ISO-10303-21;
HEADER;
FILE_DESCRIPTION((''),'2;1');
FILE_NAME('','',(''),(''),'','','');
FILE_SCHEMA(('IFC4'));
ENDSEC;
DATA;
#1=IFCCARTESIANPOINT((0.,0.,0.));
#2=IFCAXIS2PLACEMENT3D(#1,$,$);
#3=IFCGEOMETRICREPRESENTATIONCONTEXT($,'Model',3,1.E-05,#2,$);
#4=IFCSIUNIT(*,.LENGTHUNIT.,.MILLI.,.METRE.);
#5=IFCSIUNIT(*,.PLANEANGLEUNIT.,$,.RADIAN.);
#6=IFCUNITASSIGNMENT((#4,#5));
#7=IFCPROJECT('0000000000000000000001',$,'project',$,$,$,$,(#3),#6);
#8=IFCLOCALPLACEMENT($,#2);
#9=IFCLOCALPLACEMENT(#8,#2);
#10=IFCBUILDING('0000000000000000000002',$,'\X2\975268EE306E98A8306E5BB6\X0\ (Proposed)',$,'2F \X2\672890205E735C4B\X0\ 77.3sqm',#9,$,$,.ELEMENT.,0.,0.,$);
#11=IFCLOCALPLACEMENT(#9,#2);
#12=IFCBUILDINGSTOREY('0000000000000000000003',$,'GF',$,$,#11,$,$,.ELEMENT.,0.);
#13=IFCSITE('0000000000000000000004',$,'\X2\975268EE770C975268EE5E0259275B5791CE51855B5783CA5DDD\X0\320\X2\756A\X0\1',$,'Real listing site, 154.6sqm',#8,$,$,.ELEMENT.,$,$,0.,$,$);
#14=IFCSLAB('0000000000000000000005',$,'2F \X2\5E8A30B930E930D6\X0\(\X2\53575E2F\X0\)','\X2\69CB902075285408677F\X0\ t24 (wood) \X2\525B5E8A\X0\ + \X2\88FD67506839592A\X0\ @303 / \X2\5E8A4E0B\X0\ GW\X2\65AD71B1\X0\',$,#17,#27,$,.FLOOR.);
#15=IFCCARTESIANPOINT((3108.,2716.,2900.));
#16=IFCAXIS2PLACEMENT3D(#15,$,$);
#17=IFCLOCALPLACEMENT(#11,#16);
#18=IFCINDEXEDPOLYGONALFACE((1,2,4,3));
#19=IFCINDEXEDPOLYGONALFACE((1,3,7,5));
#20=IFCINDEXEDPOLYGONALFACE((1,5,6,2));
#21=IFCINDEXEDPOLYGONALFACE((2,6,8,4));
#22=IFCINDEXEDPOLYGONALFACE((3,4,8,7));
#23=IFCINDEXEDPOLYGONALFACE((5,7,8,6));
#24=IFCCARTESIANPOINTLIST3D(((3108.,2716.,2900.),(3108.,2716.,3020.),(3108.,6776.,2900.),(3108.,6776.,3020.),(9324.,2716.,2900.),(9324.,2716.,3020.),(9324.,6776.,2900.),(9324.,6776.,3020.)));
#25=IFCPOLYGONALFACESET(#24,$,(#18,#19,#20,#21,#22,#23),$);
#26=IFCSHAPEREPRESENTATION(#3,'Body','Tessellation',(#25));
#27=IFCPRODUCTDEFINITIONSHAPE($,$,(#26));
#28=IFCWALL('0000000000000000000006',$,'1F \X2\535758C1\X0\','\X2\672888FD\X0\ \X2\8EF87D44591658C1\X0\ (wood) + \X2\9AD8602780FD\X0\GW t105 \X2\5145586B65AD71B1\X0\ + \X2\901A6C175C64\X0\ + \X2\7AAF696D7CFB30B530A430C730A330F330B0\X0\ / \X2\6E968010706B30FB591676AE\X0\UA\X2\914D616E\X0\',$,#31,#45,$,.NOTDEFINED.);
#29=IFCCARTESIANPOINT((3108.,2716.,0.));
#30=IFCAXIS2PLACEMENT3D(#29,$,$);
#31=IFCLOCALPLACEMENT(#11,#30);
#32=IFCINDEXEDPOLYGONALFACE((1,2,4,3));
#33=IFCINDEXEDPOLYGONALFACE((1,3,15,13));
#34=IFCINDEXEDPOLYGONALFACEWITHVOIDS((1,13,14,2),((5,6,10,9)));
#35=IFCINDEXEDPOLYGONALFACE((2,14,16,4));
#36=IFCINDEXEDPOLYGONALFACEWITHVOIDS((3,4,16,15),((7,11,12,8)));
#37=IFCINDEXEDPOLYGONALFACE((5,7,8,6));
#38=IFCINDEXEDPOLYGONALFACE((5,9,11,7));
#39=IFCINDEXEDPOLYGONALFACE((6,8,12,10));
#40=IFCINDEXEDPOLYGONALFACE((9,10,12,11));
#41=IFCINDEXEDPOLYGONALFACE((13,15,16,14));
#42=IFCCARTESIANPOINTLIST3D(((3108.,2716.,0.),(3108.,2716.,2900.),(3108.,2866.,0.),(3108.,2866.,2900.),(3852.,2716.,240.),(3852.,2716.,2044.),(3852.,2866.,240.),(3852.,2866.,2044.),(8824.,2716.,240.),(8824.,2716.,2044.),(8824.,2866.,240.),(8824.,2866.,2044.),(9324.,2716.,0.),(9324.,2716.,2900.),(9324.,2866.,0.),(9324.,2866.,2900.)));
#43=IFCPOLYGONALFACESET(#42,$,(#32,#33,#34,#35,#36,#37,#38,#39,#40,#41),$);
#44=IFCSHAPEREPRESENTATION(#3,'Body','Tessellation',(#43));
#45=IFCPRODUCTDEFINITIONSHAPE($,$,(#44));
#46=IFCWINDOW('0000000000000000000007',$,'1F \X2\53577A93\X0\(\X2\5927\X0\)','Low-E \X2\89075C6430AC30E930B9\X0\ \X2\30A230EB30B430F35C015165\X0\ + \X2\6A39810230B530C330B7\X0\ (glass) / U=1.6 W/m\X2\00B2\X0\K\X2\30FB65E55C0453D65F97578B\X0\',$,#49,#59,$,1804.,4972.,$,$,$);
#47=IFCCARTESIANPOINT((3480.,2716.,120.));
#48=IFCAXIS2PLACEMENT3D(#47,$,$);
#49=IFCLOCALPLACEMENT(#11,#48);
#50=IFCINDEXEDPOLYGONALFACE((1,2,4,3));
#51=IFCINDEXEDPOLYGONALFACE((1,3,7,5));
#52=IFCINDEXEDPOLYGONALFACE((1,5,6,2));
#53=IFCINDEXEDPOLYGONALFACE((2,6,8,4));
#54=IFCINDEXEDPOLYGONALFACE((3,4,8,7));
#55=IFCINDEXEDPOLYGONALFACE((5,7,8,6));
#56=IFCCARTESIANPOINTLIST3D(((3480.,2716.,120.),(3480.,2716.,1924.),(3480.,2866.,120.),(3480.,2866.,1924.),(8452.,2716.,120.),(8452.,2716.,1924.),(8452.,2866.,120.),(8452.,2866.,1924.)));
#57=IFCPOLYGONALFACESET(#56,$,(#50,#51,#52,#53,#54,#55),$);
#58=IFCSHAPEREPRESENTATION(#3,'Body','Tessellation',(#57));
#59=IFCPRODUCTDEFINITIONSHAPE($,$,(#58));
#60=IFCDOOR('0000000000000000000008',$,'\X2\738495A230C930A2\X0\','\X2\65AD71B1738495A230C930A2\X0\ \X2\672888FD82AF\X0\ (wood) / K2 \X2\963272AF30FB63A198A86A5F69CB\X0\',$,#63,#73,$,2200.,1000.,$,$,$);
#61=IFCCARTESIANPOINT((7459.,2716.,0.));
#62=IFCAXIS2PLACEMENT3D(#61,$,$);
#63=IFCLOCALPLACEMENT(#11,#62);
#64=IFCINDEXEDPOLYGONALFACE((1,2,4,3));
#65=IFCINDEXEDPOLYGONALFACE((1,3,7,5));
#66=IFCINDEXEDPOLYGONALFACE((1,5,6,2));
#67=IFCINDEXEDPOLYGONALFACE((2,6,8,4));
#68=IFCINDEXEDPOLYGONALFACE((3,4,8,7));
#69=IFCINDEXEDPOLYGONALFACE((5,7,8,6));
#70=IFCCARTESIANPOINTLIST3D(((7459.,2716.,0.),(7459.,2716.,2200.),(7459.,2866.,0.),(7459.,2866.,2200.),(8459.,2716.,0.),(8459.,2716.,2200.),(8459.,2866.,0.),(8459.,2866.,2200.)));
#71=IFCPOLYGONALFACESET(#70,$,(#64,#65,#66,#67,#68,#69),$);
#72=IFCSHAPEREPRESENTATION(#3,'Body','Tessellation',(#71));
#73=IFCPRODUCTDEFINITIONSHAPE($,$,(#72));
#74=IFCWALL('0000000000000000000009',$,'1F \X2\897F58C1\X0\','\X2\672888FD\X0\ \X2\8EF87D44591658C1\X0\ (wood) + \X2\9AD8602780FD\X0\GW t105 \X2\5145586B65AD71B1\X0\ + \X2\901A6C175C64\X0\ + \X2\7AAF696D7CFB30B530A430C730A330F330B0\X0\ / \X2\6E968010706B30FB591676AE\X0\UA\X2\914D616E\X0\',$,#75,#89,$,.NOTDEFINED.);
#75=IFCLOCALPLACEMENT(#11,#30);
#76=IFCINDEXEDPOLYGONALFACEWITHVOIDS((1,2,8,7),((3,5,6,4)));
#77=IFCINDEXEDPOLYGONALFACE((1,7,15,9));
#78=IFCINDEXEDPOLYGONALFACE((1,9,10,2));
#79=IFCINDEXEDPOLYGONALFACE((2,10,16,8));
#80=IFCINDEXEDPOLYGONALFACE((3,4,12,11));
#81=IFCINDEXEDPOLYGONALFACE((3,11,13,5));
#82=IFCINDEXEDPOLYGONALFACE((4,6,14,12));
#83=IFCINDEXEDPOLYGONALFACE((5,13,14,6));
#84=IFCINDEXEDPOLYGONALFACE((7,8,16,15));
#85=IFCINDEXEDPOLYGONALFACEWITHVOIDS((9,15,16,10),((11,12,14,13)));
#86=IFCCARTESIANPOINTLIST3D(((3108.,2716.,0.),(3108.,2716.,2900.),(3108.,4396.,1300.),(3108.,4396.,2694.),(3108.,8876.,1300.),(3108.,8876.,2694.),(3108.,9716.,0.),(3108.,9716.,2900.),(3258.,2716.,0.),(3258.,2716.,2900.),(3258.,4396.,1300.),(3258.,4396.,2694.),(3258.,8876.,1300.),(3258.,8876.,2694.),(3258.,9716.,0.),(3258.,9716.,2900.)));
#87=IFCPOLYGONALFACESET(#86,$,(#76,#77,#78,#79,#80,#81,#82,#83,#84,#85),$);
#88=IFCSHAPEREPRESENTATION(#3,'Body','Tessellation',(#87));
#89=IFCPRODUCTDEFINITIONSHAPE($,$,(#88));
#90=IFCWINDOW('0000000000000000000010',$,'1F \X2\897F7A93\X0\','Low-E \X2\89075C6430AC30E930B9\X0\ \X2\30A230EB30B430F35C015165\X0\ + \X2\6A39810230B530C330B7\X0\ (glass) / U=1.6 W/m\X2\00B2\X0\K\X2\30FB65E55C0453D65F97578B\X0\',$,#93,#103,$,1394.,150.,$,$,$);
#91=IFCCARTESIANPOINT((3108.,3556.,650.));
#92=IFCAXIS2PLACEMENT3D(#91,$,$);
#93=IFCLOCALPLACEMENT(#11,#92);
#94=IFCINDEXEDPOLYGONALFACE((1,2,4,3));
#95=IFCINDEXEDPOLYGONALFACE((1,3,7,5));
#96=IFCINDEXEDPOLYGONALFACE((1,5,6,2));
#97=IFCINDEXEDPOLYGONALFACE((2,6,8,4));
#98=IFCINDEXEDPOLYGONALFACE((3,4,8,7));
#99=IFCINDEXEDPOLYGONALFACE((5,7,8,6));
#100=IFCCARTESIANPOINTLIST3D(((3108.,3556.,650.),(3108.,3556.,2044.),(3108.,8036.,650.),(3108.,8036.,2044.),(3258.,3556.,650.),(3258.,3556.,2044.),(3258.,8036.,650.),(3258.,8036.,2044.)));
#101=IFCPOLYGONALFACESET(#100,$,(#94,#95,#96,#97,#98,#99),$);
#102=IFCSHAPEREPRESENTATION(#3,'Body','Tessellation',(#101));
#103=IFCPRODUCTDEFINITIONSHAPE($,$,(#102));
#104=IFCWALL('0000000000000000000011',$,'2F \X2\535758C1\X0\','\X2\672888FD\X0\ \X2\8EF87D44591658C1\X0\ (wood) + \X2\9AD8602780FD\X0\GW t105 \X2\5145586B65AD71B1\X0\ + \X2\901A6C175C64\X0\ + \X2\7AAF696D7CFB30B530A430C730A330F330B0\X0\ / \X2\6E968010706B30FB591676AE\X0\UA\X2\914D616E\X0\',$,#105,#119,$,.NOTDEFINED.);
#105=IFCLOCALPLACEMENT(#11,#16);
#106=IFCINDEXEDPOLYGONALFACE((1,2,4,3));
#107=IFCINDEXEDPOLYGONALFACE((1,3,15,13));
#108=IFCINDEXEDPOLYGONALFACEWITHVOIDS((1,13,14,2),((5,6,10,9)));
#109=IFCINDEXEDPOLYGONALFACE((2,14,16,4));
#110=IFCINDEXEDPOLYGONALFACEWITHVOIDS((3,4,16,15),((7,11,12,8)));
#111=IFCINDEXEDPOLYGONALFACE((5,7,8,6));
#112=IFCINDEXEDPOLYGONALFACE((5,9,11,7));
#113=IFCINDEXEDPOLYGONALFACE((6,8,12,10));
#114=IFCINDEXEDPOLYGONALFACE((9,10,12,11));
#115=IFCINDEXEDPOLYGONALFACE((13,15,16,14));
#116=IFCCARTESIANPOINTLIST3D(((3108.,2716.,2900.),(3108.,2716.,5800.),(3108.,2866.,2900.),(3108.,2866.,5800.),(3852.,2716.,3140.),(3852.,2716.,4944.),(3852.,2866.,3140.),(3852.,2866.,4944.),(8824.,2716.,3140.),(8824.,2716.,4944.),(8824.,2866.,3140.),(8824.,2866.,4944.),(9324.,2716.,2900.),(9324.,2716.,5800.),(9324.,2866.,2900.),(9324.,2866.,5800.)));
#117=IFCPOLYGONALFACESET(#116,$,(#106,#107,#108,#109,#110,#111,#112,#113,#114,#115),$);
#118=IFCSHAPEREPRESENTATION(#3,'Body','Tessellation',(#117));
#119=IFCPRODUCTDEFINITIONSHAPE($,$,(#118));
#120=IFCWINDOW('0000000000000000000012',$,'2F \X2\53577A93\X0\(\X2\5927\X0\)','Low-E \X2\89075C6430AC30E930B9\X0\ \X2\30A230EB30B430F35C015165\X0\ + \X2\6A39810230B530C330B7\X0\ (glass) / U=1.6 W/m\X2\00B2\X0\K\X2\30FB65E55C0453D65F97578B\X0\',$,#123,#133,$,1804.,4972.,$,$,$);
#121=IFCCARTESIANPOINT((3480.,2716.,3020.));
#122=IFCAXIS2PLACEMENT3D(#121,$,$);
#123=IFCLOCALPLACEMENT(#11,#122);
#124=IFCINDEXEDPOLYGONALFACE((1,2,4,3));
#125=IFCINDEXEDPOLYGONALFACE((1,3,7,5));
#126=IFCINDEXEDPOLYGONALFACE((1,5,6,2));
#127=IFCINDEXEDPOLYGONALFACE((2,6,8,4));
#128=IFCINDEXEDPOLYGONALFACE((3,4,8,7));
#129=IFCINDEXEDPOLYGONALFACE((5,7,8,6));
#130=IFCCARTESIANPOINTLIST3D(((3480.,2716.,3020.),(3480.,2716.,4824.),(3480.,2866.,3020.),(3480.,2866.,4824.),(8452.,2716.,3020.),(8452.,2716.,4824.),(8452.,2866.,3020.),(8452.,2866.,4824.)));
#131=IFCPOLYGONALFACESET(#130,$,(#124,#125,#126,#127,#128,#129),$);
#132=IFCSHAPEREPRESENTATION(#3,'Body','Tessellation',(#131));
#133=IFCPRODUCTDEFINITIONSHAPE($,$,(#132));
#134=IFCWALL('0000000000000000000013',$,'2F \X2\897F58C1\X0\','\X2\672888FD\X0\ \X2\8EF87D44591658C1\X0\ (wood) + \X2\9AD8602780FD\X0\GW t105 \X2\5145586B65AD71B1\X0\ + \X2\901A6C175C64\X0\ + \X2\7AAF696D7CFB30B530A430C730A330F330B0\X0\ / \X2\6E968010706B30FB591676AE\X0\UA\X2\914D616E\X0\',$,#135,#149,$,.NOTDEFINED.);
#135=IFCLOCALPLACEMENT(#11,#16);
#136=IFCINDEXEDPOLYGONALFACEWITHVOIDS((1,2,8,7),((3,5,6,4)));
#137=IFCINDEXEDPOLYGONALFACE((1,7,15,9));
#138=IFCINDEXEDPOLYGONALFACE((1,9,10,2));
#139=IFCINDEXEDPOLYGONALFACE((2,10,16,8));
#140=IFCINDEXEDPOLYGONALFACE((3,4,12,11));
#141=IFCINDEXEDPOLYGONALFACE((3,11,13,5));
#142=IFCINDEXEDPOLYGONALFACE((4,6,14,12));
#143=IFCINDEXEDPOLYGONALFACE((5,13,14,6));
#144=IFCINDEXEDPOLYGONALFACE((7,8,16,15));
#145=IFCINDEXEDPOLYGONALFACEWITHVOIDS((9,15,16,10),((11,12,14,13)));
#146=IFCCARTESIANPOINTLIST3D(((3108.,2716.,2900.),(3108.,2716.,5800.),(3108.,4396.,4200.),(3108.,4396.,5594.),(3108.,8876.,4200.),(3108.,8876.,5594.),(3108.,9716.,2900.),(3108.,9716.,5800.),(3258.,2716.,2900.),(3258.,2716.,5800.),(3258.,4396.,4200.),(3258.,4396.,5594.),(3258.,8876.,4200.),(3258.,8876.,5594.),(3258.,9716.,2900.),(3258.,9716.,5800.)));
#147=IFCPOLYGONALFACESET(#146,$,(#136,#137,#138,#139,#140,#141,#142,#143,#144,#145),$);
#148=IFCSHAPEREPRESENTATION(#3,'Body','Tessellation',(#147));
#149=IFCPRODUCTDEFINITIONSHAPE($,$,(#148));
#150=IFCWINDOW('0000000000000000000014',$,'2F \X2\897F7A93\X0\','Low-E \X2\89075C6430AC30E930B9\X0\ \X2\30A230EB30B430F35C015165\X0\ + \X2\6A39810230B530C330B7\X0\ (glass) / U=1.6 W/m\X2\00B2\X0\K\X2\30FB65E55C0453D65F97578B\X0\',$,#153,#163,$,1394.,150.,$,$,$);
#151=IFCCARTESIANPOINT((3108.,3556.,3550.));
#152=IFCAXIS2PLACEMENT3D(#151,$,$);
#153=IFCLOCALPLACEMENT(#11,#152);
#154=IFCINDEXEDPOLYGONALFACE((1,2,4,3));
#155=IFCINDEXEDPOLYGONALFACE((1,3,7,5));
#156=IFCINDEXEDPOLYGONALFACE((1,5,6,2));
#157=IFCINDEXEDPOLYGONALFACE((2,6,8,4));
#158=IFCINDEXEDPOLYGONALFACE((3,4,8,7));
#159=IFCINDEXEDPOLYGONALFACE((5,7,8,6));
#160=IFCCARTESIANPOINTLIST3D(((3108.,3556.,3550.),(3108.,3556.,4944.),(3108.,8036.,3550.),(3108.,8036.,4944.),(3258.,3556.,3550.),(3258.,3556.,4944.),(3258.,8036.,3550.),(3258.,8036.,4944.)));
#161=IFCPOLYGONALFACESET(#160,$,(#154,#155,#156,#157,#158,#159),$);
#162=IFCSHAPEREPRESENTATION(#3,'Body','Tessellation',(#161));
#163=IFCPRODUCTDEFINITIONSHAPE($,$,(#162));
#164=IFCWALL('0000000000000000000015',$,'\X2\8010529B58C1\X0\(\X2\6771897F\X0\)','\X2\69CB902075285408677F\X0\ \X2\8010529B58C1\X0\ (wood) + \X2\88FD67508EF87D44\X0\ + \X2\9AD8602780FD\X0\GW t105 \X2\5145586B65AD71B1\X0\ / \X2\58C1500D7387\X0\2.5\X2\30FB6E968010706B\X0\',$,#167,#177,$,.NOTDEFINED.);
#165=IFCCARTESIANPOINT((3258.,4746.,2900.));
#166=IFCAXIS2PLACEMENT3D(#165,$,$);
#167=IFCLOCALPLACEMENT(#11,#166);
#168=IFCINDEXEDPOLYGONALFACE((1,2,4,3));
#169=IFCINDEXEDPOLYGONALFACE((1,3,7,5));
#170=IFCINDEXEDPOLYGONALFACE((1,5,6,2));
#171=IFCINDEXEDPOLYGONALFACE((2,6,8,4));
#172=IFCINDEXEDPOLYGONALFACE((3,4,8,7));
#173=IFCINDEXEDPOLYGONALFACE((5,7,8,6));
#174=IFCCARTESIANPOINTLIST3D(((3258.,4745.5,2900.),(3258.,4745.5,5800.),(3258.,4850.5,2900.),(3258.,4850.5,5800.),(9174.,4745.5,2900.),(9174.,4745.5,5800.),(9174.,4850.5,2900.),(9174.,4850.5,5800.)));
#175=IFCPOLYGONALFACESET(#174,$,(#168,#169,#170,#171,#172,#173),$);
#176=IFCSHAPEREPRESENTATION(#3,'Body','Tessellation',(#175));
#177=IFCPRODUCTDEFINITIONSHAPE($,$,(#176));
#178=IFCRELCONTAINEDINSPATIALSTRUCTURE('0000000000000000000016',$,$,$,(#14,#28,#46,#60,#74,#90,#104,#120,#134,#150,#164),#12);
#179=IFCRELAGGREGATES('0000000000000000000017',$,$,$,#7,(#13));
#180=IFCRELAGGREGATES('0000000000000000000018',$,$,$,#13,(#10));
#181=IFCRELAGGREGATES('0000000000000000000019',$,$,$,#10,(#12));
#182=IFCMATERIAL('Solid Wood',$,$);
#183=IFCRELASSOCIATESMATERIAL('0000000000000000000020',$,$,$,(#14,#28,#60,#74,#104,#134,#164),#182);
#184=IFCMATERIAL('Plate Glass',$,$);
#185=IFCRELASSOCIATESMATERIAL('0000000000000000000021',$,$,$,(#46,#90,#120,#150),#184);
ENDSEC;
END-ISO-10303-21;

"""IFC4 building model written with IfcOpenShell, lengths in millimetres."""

from ifc_helpers import new_model, si_unit, frame, frame_2d, origin, place, context, project, spatial, rectangle, extrude, material, element, fill, save


model = new_model("IFC4")

# Units and contexts
model_context = context("Model", 3, precision=1e-05, world=origin())
ifc_project = project(units=[si_unit("LENGTHUNIT", "METRE", prefix="MILLI"), si_unit("PLANEANGLEUNIT", "RADIAN")], contexts=[model_context])

# Site, building, storey
site_placement = place(None, origin())
site = spatial("IfcSite", under=ifc_project, at=site_placement, Name="青森県青森市大字野内字菊川320番1", ObjectType="Real listing site, 154.6sqm", CompositionType="ELEMENT", RefElevation=0.0)
building_placement = place(site_placement, origin())
building = spatial("IfcBuilding", under=site, at=building_placement, Name="青森の風の家 (Proposed)", ObjectType="2F 木造平屋 77.3sqm", CompositionType="ELEMENT", ElevationOfRefHeight=0.0, ElevationOfTerrain=0.0)
storey_placement = place(building_placement, origin())
storey = spatial("IfcBuildingStorey", under=building, at=storey_placement, Name="GF", CompositionType="ELEMENT", Elevation=0.0)

# Slab
ifc_material_1 = material(Name="Solid Wood")
slab_1_placement = place(storey_placement, frame((3108.0, 2716.0, 2900.0)))
element("IfcSlab", 1, at=slab_1_placement, inside=storey, material=ifc_material_1, Name="2F 床スラブ(南帯)", Description="構造用合板 t24 (wood) 剛床 + 製材根太 @303 / 床下 GW断熱", PredefinedType="FLOOR", context=model_context, shape_type="SweptSolid", body=[
    extrude(rectangle(XDim=6216.0, YDim=4060.0, at=frame_2d((3108.0, 2030.0))), frame((3108.0, 2716.0, 2900.0)), (0.0, 0.0, 1.0), 120.0),
])

# Wall, openings, window, door
wall_1_placement = place(storey_placement, frame((3108.0, 2716.0, 0.0)))
wall_1 = element("IfcWall", 2, at=wall_1_placement, inside=storey, material=ifc_material_1, Name="1F 南壁", Description="木製 軸組外壁 (wood) + 高性能GW t105 充填断熱 + 通気層 + 窯業系サイディング / 準耐火・外皮UA配慮", PredefinedType="NOTDEFINED", context=model_context, shape_type="SweptSolid", body=[
    extrude(rectangle(XDim=6216.0, YDim=150.0, at=frame_2d((3108.0, 75.0))), frame((3108.0, 2716.0, 0.0)), (0.0, 0.0, 1.0), 2900.0),
])
opening_1_placement = place(storey_placement, frame((3480.0, 2716.0, 120.0)))
opening_1 = element("IfcOpeningElement", 3, at=opening_1_placement, cuts=wall_1, PredefinedType="NOTDEFINED", context=model_context, shape_type="SweptSolid", body=[
    extrude(rectangle(XDim=4972.0, YDim=150.0, at=frame_2d((2486.0, 75.0))), frame((3480.0, 2716.0, 120.0)), (0.0, 0.0, 1.0), 1804.0),
])
opening_2_placement = place(storey_placement, frame((7459.0, 2716.0, 0.0)))
opening_2 = element("IfcOpeningElement", 4, at=opening_2_placement, cuts=wall_1, PredefinedType="NOTDEFINED", context=model_context, shape_type="SweptSolid", body=[
    extrude(rectangle(XDim=1000.0, YDim=150.0, at=frame_2d((500.0, 75.0))), frame((7459.0, 2716.0, 0.0)), (0.0, 0.0, 1.0), 2200.0),
])
ifc_material_2 = material(Name="Plate Glass")
window_1_placement = place(storey_placement, frame((3480.0, 2716.0, 120.0)))
window_1 = element("IfcWindow", 5, at=window_1_placement, inside=storey, material=ifc_material_2, Name="1F 南窓(大)", Description="Low-E 複層ガラス アルゴン封入 + 樹脂サッシ (glass) / U=1.6 W/m²K・日射取得型", OverallHeight=1804.0, OverallWidth=4972.0, context=model_context, shape_type="SweptSolid", body=[
    extrude(rectangle(XDim=4972.0, YDim=150.0, at=frame_2d((2486.0, 75.0))), frame((3480.0, 2716.0, 120.0)), (0.0, 0.0, 1.0), 1804.0),
])
fill(opening_1, window_1)
door_placement = place(storey_placement, frame((7459.0, 2716.0, 0.0)))
door = element("IfcDoor", 6, at=door_placement, inside=storey, material=ifc_material_1, Name="玄関ドア", Description="断熱玄関ドア 木製芯 (wood) / K2 防犯・採風機構", OverallHeight=2200.0, OverallWidth=1000.0, context=model_context, shape_type="SweptSolid", body=[
    extrude(rectangle(XDim=1000.0, YDim=150.0, at=frame_2d((500.0, 75.0))), frame((7459.0, 2716.0, 0.0)), (0.0, 0.0, 1.0), 2200.0),
])
fill(opening_2, door)

# Wall, opening, window
wall_2_placement = place(storey_placement, frame((3108.0, 2716.0, 0.0)))
wall_2 = element("IfcWall", 7, at=wall_2_placement, inside=storey, material=ifc_material_1, Name="1F 西壁", Description="木製 軸組外壁 (wood) + 高性能GW t105 充填断熱 + 通気層 + 窯業系サイディング / 準耐火・外皮UA配慮", PredefinedType="NOTDEFINED", context=model_context, shape_type="SweptSolid", body=[
    extrude(rectangle(XDim=150.0, YDim=7000.0, at=frame_2d((75.0, 3500.0))), frame((3108.0, 2716.0, 0.0)), (0.0, 0.0, 1.0), 2900.0),
])
opening_3_placement = place(storey_placement, frame((3108.0, 3556.0, 650.0)))
opening_3 = element("IfcOpeningElement", 8, at=opening_3_placement, cuts=wall_2, PredefinedType="NOTDEFINED", context=model_context, shape_type="SweptSolid", body=[
    extrude(rectangle(XDim=150.0, YDim=4480.0, at=frame_2d((75.0, 2240.0))), frame((3108.0, 3556.0, 650.0)), (0.0, 0.0, 1.0), 1394.0),
])
window_2_placement = place(storey_placement, frame((3108.0, 3556.0, 650.0)))
window_2 = element("IfcWindow", 9, at=window_2_placement, inside=storey, material=ifc_material_2, Name="1F 西窓", Description="Low-E 複層ガラス アルゴン封入 + 樹脂サッシ (glass) / U=1.6 W/m²K・日射取得型", OverallHeight=1394.0, OverallWidth=150.0, context=model_context, shape_type="SweptSolid", body=[
    extrude(rectangle(XDim=150.0, YDim=4480.0, at=frame_2d((75.0, 2240.0))), frame((3108.0, 3556.0, 650.0)), (0.0, 0.0, 1.0), 1394.0),
])
fill(opening_3, window_2)

# Walls, openings, windows
wall_3_placement = place(storey_placement, frame((3108.0, 2716.0, 2900.0)))
wall_3 = element("IfcWall", 10, at=wall_3_placement, inside=storey, material=ifc_material_1, Name="2F 南壁", Description="木製 軸組外壁 (wood) + 高性能GW t105 充填断熱 + 通気層 + 窯業系サイディング / 準耐火・外皮UA配慮", PredefinedType="NOTDEFINED", context=model_context, shape_type="SweptSolid", body=[
    extrude(rectangle(XDim=6216.0, YDim=150.0, at=frame_2d((3108.0, 75.0))), frame((3108.0, 2716.0, 2900.0)), (0.0, 0.0, 1.0), 2900.0),
])
opening_4_placement = place(storey_placement, frame((3480.0, 2716.0, 3020.0)))
opening_4 = element("IfcOpeningElement", 11, at=opening_4_placement, cuts=wall_3, PredefinedType="NOTDEFINED", context=model_context, shape_type="SweptSolid", body=[
    extrude(rectangle(XDim=4972.0, YDim=150.0, at=frame_2d((2486.0, 75.0))), frame((3480.0, 2716.0, 3020.0)), (0.0, 0.0, 1.0), 1804.0),
])
window_3_placement = place(storey_placement, frame((3480.0, 2716.0, 3020.0)))
window_3 = element("IfcWindow", 12, at=window_3_placement, inside=storey, material=ifc_material_2, Name="2F 南窓(大)", Description="Low-E 複層ガラス アルゴン封入 + 樹脂サッシ (glass) / U=1.6 W/m²K・日射取得型", OverallHeight=1804.0, OverallWidth=4972.0, context=model_context, shape_type="SweptSolid", body=[
    extrude(rectangle(XDim=4972.0, YDim=150.0, at=frame_2d((2486.0, 75.0))), frame((3480.0, 2716.0, 3020.0)), (0.0, 0.0, 1.0), 1804.0),
])
fill(opening_4, window_3)
wall_4_placement = place(storey_placement, frame((3108.0, 2716.0, 2900.0)))
wall_4 = element("IfcWall", 13, at=wall_4_placement, inside=storey, material=ifc_material_1, Name="2F 西壁", Description="木製 軸組外壁 (wood) + 高性能GW t105 充填断熱 + 通気層 + 窯業系サイディング / 準耐火・外皮UA配慮", PredefinedType="NOTDEFINED", context=model_context, shape_type="SweptSolid", body=[
    extrude(rectangle(XDim=150.0, YDim=7000.0, at=frame_2d((75.0, 3500.0))), frame((3108.0, 2716.0, 2900.0)), (0.0, 0.0, 1.0), 2900.0),
])
opening_5_placement = place(storey_placement, frame((3108.0, 3556.0, 3550.0)))
opening_5 = element("IfcOpeningElement", 14, at=opening_5_placement, cuts=wall_4, PredefinedType="NOTDEFINED", context=model_context, shape_type="SweptSolid", body=[
    extrude(rectangle(XDim=150.0, YDim=4480.0, at=frame_2d((75.0, 2240.0))), frame((3108.0, 3556.0, 3550.0)), (0.0, 0.0, 1.0), 1394.0),
])
window_4_placement = place(storey_placement, frame((3108.0, 3556.0, 3550.0)))
window_4 = element("IfcWindow", 15, at=window_4_placement, inside=storey, material=ifc_material_2, Name="2F 西窓", Description="Low-E 複層ガラス アルゴン封入 + 樹脂サッシ (glass) / U=1.6 W/m²K・日射取得型", OverallHeight=1394.0, OverallWidth=150.0, context=model_context, shape_type="SweptSolid", body=[
    extrude(rectangle(XDim=150.0, YDim=4480.0, at=frame_2d((75.0, 2240.0))), frame((3108.0, 3556.0, 3550.0)), (0.0, 0.0, 1.0), 1394.0),
])
fill(opening_5, window_4)

# Wall
wall_5_placement = place(storey_placement, frame((3258.0, 4746.0, 2900.0)))
element("IfcWall", 16, at=wall_5_placement, inside=storey, material=ifc_material_1, Name="耐力壁(東西)", Description="構造用合板 耐力壁 (wood) + 製材軸組 + 高性能GW t105 充填断熱 / 壁倍率2.5・準耐火", PredefinedType="NOTDEFINED", context=model_context, shape_type="SweptSolid", body=[
    extrude(rectangle(XDim=5916.0, YDim=105.0, at=frame_2d((2958.0, 52.0))), frame((3258.0, 4746.0, 2900.0)), (0.0, 0.0, 1.0), 2900.0),
])

save(model, "model.ifc")
